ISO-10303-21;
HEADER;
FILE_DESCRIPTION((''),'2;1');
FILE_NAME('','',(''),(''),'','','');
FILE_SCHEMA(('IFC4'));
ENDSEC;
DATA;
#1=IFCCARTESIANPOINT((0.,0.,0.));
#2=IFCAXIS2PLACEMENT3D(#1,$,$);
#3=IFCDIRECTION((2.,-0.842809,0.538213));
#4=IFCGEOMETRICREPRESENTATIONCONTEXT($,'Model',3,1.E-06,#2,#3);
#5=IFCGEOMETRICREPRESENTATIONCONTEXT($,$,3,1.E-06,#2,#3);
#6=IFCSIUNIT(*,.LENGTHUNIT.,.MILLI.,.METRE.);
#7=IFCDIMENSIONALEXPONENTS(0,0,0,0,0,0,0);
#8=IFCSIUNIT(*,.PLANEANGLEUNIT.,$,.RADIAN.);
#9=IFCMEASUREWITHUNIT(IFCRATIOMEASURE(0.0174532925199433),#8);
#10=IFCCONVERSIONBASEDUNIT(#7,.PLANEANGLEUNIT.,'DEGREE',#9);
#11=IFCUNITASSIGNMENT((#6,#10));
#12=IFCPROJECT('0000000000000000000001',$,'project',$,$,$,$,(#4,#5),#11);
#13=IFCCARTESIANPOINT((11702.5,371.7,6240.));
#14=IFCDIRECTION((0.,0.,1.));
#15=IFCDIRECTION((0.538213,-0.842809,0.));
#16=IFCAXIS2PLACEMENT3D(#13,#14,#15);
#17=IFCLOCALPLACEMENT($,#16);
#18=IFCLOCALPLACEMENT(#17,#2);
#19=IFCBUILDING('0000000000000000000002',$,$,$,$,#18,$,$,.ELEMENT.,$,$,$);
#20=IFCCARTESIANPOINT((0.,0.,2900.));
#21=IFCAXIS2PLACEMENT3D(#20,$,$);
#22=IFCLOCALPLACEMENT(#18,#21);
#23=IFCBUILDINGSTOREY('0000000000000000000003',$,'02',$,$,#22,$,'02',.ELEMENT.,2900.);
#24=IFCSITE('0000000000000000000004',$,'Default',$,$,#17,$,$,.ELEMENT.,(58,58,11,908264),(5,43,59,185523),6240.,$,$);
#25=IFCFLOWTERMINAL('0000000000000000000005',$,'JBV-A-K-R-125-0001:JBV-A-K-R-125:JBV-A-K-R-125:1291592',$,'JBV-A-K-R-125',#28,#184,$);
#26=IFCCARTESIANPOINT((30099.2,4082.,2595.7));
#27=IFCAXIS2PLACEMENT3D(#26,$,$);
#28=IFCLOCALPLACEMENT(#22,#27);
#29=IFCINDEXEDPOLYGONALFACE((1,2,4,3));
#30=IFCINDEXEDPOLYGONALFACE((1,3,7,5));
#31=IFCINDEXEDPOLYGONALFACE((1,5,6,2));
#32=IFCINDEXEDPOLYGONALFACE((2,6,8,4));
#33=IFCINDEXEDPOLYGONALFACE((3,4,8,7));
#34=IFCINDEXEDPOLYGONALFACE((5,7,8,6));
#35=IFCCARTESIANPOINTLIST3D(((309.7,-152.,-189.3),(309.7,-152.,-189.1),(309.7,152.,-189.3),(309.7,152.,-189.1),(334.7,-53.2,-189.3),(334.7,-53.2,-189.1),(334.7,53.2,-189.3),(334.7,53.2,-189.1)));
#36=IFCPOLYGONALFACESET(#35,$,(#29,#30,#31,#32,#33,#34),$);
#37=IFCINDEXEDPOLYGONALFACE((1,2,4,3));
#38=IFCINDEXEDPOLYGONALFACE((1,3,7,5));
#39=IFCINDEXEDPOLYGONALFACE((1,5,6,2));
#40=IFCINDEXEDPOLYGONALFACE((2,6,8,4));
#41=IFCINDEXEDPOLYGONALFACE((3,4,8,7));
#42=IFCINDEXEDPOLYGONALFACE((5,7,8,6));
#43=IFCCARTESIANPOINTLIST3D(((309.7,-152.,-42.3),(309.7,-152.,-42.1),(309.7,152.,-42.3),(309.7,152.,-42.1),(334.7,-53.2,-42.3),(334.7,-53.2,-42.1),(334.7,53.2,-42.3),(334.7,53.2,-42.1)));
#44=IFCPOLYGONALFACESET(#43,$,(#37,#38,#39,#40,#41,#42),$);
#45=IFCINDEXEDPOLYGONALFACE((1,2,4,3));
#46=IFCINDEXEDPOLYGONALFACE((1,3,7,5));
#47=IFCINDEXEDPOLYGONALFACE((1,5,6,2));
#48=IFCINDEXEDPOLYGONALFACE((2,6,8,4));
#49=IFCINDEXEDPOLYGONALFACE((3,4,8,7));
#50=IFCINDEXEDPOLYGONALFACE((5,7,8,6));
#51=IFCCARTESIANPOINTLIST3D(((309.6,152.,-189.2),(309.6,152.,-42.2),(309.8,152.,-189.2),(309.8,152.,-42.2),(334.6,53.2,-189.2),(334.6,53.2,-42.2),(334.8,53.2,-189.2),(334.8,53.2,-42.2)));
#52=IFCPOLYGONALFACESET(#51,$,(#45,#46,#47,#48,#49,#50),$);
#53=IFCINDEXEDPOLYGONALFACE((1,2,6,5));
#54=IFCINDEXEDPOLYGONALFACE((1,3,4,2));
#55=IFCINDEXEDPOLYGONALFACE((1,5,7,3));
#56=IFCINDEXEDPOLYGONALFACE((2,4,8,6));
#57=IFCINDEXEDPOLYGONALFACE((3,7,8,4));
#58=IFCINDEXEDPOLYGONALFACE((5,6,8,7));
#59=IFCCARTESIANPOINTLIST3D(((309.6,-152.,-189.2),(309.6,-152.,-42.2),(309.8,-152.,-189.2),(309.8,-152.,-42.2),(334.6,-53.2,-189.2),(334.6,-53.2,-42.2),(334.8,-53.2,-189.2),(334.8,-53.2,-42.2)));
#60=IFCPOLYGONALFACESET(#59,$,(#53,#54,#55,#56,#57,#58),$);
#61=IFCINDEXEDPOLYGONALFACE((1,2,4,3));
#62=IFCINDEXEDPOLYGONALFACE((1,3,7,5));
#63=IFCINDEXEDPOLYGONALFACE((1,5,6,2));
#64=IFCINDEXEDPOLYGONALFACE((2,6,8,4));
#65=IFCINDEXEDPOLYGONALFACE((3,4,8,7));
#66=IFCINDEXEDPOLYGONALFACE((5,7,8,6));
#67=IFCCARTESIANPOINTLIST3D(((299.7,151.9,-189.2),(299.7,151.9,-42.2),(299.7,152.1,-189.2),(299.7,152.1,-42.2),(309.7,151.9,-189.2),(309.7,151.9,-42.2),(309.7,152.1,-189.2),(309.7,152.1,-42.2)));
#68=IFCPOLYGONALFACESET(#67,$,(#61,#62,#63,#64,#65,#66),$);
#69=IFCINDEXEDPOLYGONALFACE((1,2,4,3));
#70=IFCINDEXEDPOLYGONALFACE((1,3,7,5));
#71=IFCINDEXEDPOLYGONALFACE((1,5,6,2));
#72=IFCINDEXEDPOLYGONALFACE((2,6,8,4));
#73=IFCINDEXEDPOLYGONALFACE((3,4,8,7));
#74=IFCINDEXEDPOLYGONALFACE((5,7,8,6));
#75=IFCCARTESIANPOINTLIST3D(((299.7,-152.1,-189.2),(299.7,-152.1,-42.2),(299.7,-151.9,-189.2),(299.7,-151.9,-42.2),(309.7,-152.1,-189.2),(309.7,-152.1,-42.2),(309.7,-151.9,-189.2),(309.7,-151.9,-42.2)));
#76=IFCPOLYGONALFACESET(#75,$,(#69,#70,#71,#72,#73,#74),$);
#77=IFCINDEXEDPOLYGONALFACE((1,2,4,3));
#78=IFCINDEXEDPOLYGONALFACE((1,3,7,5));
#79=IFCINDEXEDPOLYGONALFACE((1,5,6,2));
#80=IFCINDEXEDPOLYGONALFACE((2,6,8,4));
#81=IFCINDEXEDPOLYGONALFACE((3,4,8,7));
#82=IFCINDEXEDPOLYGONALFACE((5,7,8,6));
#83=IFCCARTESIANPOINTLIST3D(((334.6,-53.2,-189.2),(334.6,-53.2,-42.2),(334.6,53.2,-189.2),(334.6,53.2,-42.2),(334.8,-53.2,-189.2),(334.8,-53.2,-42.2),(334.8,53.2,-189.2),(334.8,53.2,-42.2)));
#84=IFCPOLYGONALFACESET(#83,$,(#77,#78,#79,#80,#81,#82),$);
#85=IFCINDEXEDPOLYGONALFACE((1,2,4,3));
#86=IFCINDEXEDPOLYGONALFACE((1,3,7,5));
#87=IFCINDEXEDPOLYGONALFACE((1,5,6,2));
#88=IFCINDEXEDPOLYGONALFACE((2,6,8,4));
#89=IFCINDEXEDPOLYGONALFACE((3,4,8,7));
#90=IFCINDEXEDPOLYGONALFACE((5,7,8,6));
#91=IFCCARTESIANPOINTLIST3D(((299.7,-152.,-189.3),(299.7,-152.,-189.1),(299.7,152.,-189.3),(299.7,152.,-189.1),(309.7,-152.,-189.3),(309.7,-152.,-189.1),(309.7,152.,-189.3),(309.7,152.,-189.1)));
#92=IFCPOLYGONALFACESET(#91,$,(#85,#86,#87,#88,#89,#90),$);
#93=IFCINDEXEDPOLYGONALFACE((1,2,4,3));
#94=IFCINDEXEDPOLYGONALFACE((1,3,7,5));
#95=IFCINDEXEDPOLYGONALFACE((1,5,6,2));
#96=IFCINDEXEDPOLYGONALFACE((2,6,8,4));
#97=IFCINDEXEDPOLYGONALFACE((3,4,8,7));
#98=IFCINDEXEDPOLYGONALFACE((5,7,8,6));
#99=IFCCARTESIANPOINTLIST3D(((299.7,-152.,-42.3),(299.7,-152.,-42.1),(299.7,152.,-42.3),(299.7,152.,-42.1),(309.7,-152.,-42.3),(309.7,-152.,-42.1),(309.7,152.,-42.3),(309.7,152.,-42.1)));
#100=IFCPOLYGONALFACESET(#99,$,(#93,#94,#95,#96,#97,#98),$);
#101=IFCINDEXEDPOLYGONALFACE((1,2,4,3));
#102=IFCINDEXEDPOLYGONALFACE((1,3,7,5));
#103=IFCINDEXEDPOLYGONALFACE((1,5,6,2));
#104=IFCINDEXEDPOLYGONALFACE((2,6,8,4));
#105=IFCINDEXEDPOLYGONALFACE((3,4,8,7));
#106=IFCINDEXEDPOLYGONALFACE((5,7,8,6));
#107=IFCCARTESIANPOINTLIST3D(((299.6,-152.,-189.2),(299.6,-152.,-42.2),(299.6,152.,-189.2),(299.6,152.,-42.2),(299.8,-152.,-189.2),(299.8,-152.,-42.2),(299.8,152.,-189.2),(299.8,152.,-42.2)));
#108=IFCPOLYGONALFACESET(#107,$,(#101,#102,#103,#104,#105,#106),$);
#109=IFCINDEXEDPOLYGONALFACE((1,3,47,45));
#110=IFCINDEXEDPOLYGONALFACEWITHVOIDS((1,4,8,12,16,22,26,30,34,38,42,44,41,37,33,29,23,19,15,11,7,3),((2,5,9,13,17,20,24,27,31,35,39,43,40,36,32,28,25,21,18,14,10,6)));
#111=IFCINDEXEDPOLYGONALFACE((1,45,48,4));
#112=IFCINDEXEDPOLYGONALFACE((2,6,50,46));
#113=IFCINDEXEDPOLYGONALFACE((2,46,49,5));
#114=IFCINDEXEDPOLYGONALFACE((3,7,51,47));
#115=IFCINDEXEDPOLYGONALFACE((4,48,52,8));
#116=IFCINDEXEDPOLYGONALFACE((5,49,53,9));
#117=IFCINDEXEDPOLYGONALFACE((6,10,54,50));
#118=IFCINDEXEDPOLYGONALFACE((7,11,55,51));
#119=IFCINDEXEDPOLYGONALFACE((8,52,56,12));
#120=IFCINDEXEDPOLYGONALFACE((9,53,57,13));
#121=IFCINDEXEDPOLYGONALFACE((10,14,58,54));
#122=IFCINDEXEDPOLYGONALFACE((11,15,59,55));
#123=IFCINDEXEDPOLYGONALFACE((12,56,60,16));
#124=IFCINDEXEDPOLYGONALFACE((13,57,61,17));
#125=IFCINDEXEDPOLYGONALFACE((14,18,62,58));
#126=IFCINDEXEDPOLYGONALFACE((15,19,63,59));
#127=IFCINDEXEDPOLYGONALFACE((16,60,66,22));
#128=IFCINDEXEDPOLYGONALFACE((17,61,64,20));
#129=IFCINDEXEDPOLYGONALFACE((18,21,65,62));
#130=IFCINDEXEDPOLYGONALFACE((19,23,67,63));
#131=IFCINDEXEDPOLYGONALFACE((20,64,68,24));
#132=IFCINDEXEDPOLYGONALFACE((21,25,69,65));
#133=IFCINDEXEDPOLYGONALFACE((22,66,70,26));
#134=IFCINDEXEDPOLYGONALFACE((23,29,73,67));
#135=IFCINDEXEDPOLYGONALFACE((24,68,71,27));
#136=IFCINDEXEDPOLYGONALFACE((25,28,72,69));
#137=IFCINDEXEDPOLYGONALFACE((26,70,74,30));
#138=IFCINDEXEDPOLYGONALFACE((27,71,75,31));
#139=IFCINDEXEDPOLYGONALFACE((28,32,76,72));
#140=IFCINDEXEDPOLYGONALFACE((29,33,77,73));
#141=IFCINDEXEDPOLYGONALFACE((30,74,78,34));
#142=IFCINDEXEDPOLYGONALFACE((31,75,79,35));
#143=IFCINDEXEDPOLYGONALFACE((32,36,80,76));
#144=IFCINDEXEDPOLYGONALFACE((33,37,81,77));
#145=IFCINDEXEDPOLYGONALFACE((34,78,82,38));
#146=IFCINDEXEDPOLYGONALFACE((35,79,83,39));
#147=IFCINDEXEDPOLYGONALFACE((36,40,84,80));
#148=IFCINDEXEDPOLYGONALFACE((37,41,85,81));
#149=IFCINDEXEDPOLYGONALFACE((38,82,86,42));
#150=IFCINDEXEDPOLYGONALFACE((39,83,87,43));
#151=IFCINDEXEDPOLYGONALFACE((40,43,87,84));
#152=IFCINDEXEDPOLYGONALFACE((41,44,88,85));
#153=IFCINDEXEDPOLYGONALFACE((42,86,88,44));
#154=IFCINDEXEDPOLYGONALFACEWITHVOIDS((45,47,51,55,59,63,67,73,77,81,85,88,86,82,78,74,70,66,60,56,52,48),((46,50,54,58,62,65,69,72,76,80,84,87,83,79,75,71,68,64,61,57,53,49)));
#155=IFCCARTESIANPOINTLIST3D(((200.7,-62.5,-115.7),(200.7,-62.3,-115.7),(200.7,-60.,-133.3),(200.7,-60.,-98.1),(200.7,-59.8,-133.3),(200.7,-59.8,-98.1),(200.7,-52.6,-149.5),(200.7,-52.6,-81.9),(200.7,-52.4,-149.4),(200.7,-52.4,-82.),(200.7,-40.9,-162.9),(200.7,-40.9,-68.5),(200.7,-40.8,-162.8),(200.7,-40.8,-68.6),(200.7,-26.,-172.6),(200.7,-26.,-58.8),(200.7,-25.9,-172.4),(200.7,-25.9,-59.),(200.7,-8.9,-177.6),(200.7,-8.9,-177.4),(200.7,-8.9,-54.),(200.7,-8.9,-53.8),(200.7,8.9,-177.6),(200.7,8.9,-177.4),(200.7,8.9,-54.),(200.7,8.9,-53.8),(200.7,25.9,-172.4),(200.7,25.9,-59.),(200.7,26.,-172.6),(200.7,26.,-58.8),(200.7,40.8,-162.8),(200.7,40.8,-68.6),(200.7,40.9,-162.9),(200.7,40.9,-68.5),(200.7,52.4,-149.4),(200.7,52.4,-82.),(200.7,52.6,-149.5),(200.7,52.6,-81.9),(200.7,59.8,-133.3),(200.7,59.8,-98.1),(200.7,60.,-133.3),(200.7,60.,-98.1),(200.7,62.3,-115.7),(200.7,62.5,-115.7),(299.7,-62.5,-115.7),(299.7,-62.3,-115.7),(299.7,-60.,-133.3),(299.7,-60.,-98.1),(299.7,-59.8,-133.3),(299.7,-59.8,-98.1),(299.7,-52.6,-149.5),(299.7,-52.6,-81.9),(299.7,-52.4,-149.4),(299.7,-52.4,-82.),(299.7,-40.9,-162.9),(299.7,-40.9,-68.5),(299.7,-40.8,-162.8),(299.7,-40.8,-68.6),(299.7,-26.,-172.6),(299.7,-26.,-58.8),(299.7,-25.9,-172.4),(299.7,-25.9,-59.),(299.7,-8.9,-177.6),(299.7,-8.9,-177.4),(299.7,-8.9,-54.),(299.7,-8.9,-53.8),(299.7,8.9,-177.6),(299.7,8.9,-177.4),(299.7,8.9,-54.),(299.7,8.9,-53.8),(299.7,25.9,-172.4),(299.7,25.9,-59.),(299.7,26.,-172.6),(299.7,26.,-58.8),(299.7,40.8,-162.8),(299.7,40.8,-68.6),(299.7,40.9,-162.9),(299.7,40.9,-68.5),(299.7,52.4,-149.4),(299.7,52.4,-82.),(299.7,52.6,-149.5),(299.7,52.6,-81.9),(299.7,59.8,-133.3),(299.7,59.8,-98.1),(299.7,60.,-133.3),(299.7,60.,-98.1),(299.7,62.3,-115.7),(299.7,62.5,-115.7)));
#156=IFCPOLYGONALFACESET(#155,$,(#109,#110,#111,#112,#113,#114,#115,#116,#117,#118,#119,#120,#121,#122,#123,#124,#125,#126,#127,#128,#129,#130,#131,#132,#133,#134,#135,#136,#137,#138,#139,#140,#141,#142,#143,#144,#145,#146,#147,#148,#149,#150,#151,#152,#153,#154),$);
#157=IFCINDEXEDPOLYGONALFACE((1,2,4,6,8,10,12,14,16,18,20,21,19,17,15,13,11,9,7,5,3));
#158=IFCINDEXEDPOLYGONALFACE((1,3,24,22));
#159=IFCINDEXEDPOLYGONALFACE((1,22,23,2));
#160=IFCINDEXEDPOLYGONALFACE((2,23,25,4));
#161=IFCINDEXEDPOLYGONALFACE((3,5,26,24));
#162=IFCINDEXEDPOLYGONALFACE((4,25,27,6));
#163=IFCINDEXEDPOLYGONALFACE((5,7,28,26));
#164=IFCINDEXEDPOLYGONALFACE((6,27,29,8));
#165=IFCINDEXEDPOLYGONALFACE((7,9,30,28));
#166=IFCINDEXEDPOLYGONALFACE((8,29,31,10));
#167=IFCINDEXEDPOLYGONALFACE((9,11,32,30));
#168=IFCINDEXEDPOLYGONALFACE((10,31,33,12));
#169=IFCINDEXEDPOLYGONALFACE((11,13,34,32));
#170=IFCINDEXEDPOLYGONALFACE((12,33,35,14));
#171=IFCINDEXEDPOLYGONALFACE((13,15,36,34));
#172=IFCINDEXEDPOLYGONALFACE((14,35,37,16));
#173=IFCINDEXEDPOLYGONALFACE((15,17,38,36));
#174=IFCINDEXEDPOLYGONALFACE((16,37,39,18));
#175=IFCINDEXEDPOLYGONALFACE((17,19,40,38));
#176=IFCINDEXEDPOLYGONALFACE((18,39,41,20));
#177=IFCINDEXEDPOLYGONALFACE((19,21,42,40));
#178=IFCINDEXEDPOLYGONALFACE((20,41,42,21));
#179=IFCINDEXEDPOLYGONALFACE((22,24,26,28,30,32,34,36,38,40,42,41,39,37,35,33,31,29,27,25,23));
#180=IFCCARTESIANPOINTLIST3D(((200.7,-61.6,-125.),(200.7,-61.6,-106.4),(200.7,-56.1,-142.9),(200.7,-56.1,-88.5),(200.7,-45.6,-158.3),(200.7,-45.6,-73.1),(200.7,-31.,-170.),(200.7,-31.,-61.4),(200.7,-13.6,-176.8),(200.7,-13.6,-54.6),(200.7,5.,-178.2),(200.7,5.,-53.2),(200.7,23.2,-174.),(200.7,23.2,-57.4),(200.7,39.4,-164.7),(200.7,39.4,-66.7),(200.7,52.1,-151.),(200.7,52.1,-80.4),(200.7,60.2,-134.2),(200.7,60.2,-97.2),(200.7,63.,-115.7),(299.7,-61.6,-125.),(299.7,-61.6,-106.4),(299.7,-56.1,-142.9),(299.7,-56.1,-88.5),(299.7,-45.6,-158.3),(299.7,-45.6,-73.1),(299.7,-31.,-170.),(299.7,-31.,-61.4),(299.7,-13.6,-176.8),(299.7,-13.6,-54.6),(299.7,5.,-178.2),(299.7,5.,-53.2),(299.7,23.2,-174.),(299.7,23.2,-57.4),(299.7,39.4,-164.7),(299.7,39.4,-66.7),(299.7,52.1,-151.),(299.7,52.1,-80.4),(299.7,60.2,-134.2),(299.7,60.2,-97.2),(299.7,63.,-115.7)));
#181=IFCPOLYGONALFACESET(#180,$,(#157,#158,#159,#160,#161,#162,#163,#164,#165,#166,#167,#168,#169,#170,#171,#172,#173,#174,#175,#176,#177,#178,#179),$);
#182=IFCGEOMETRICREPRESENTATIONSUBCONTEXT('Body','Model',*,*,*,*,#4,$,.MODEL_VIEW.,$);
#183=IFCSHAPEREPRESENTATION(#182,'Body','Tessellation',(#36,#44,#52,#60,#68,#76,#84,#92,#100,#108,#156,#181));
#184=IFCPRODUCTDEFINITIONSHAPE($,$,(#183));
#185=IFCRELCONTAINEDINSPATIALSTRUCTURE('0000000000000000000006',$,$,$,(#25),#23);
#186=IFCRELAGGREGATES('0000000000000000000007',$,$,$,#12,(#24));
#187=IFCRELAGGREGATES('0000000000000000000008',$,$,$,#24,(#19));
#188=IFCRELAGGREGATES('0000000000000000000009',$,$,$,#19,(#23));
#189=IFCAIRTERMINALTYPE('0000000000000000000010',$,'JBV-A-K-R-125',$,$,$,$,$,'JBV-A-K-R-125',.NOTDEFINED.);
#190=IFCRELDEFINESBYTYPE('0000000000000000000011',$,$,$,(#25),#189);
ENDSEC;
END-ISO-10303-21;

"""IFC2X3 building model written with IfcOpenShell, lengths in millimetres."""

from ifc_helpers import new_model, entity, si_unit, converted_unit, direction, frame, frame_2d, origin, origin_2d_with_axis, place, context, subcontext, project, spatial, polyline, circle_curve, parameter, trimmed, segment, composite_curve, rectangle, circle, outline, extrude, source, transform, mapped, type_object, type_shapes, element, save


model = new_model("IFC2X3")

# Units and contexts
model_context = context("Model", 3, precision=1e-06, world=origin(), true_north=direction((2.0, -0.842809, 0.538213)))
context_of_model = context(None, 3, precision=1e-06, world=origin(), true_north=direction((2.0, -0.842809, 0.538213)))
body_context = subcontext(model_context, "Body", "Model", "MODEL_VIEW")
ifc_project = project(units=[si_unit("LENGTHUNIT", "METRE", prefix="MILLI"), converted_unit("PLANEANGLEUNIT", "DEGREE", entity("IfcRatioMeasure", 0.0174532925199433), si_unit("PLANEANGLEUNIT", "RADIAN"), dimensions=[0, 0, 0, 0, 0, 0, 0])], contexts=[model_context, context_of_model])

# Site, building, storey
site_placement = place(None, frame((11702.5, 371.7, 6240.0), z_axis=(0.0, 0.0, 1.0), x_axis=(0.538213, -0.842809, 0.0)))
site = spatial("IfcSite", under=ifc_project, at=site_placement, Name="Default", CompositionType="ELEMENT", RefLatitude=(58, 58, 11, 908264), RefLongitude=(5, 43, 59, 185523), RefElevation=6240.0)
building_placement = place(site_placement, origin())
building = spatial("IfcBuilding", under=site, at=building_placement, CompositionType="ELEMENT")
storey_placement = place(building_placement, frame((0.0, 0.0, 2900.0)))
storey = spatial("IfcBuildingStorey", under=building, at=storey_placement, Name="02", LongName="02", CompositionType="ELEMENT", Elevation=2900.0)

# Flow terminal
air_terminal_type_1 = type_object("IfcAirTerminalType", Name="JBV-A-K-R-125", ElementType="JBV-A-K-R-125", PredefinedType="NOTDEFINED")
shared_shape_1 = source(origin(), body_context, "Body", "SweptSolid", [
    extrude(outline(polyline([(-152.0, -12.5), (152.0, -12.5), (53.2, 12.5), (-53.2, 12.5), (-152.0, -12.5)])), frame((322.2, 0.0, -189.3), z_axis=(0.0, 0.0, 1.0), x_axis=(0.0, -1.0, 0.0)), (0.0, 0.0, 1.0), 0.2),
    extrude(outline(polyline([(-152.0, -12.5), (152.0, -12.5), (53.2, 12.5), (-53.2, 12.5), (-152.0, -12.5)])), frame((322.2, 0.0, -42.3), z_axis=(0.0, 0.0, 1.0), x_axis=(0.0, -1.0, 0.0)), (0.0, 0.0, 1.0), 0.2),
    extrude(rectangle(XDim=0.2, YDim=101.9, at=frame_2d((0.0, 0.0), x_axis=(1.0, 0.0))), frame((322.2, 102.6, -189.2), z_axis=(0.0, 0.0, 1.0), x_axis=(0.969446, 0.245305, 0.0)), (0.0, 0.0, 1.0), 147.0),
    extrude(rectangle(XDim=0.2, YDim=101.9, at=frame_2d((0.0, 0.0), x_axis=(1.0, 0.0))), frame((322.2, -102.6, -189.2), z_axis=(0.0, 0.0, 1.0), x_axis=(-0.969446, 0.245305, 0.0)), (0.0, 0.0, 1.0), 147.0),
    extrude(rectangle(XDim=0.2, YDim=10.0, at=frame_2d((0.0, 0.0), x_axis=(1.0, 0.0))), frame((304.7, 152.0, -189.2), z_axis=(0.0, 0.0, 1.0), x_axis=(0.0, 1.0, 0.0)), (0.0, 0.0, 1.0), 147.0),
    extrude(rectangle(XDim=0.2, YDim=10.0, at=frame_2d((0.0, 0.0), x_axis=(1.0, 0.0))), frame((304.7, -152.0, -189.2), z_axis=(0.0, 0.0, 1.0), x_axis=(0.0, 1.0, 0.0)), (0.0, 0.0, 1.0), 147.0),
    extrude(rectangle(XDim=0.2, YDim=106.4, at=frame_2d((0.0, 0.0), x_axis=(1.0, 0.0))), frame((334.7, 0.0, -189.2)), (0.0, 0.0, 1.0), 147.0),
    extrude(rectangle(XDim=304.0, YDim=10.0, at=frame_2d((0.0, 0.0), x_axis=(1.0, 0.0))), frame((304.7, 0.0, -189.3), z_axis=(0.0, 0.0, 1.0), x_axis=(0.0, -1.0, 0.0)), (0.0, 0.0, 1.0), 0.2),
    extrude(rectangle(XDim=304.0, YDim=10.0, at=frame_2d((0.0, 0.0), x_axis=(1.0, 0.0))), frame((304.7, 0.0, -42.3), z_axis=(0.0, 0.0, 1.0), x_axis=(0.0, -1.0, 0.0)), (0.0, 0.0, 1.0), 0.2),
    extrude(rectangle(XDim=0.2, YDim=304.0, at=frame_2d((0.0, 0.0), x_axis=(1.0, 0.0))), frame((299.7, 0.0, -189.2)), (0.0, 0.0, 1.0), 147.0),
    extrude(outline(composite_curve([segment(trimmed(circle_curve(origin_2d_with_axis(), 62.5), [parameter(0.0)], [parameter(180.0)], True, "PARAMETER"), True, "CONTINUOUS"), segment(trimmed(circle_curve(origin_2d_with_axis(), 62.5), [parameter(180.0)], [parameter(360.0)], True, "PARAMETER"), True, "CONTINUOUS")], self_intersect=False), holes=[composite_curve([segment(trimmed(circle_curve(origin_2d_with_axis(), 62.3), [parameter(180.0)], [parameter(360.0)], True, "PARAMETER"), False, "CONTINUOUS"), segment(trimmed(circle_curve(origin_2d_with_axis(), 62.3), [parameter(0.0)], [parameter(180.0)], True, "PARAMETER"), False, "CONTINUOUS")], self_intersect=False)]), frame((200.7, 0.0, -115.7), z_axis=(1.0, 0.0, 0.0), x_axis=(0.0, 1.0, 0.0)), (0.0, 0.0, 1.0), 99.0),
    extrude(circle(Radius=62.6, at=frame_2d((0.0, 0.0), x_axis=(1.0, 0.0))), frame((200.7, 0.3, -115.7), z_axis=(1.0, 0.0, 0.0), x_axis=(0.0, 1.0, 0.0)), (0.0, 0.0, 1.0), 99.0),
])
type_shapes(air_terminal_type_1, [shared_shape_1])
flow_terminal_1_placement = place(storey_placement, frame((30099.2, 4082.0, 2595.7)))
element("IfcFlowTerminal", 1, at=flow_terminal_1_placement, inside=storey, type_object=air_terminal_type_1, Name="JBV-A-K-R-125-0001:JBV-A-K-R-125:JBV-A-K-R-125:1291592", ObjectType="JBV-A-K-R-125", context=body_context, shape_type="MappedRepresentation", body=[
    mapped(shared_shape_1, transform((0.0, 0.0, 0.0), scale=1.0)),
])

save(model, "model.ifc")
